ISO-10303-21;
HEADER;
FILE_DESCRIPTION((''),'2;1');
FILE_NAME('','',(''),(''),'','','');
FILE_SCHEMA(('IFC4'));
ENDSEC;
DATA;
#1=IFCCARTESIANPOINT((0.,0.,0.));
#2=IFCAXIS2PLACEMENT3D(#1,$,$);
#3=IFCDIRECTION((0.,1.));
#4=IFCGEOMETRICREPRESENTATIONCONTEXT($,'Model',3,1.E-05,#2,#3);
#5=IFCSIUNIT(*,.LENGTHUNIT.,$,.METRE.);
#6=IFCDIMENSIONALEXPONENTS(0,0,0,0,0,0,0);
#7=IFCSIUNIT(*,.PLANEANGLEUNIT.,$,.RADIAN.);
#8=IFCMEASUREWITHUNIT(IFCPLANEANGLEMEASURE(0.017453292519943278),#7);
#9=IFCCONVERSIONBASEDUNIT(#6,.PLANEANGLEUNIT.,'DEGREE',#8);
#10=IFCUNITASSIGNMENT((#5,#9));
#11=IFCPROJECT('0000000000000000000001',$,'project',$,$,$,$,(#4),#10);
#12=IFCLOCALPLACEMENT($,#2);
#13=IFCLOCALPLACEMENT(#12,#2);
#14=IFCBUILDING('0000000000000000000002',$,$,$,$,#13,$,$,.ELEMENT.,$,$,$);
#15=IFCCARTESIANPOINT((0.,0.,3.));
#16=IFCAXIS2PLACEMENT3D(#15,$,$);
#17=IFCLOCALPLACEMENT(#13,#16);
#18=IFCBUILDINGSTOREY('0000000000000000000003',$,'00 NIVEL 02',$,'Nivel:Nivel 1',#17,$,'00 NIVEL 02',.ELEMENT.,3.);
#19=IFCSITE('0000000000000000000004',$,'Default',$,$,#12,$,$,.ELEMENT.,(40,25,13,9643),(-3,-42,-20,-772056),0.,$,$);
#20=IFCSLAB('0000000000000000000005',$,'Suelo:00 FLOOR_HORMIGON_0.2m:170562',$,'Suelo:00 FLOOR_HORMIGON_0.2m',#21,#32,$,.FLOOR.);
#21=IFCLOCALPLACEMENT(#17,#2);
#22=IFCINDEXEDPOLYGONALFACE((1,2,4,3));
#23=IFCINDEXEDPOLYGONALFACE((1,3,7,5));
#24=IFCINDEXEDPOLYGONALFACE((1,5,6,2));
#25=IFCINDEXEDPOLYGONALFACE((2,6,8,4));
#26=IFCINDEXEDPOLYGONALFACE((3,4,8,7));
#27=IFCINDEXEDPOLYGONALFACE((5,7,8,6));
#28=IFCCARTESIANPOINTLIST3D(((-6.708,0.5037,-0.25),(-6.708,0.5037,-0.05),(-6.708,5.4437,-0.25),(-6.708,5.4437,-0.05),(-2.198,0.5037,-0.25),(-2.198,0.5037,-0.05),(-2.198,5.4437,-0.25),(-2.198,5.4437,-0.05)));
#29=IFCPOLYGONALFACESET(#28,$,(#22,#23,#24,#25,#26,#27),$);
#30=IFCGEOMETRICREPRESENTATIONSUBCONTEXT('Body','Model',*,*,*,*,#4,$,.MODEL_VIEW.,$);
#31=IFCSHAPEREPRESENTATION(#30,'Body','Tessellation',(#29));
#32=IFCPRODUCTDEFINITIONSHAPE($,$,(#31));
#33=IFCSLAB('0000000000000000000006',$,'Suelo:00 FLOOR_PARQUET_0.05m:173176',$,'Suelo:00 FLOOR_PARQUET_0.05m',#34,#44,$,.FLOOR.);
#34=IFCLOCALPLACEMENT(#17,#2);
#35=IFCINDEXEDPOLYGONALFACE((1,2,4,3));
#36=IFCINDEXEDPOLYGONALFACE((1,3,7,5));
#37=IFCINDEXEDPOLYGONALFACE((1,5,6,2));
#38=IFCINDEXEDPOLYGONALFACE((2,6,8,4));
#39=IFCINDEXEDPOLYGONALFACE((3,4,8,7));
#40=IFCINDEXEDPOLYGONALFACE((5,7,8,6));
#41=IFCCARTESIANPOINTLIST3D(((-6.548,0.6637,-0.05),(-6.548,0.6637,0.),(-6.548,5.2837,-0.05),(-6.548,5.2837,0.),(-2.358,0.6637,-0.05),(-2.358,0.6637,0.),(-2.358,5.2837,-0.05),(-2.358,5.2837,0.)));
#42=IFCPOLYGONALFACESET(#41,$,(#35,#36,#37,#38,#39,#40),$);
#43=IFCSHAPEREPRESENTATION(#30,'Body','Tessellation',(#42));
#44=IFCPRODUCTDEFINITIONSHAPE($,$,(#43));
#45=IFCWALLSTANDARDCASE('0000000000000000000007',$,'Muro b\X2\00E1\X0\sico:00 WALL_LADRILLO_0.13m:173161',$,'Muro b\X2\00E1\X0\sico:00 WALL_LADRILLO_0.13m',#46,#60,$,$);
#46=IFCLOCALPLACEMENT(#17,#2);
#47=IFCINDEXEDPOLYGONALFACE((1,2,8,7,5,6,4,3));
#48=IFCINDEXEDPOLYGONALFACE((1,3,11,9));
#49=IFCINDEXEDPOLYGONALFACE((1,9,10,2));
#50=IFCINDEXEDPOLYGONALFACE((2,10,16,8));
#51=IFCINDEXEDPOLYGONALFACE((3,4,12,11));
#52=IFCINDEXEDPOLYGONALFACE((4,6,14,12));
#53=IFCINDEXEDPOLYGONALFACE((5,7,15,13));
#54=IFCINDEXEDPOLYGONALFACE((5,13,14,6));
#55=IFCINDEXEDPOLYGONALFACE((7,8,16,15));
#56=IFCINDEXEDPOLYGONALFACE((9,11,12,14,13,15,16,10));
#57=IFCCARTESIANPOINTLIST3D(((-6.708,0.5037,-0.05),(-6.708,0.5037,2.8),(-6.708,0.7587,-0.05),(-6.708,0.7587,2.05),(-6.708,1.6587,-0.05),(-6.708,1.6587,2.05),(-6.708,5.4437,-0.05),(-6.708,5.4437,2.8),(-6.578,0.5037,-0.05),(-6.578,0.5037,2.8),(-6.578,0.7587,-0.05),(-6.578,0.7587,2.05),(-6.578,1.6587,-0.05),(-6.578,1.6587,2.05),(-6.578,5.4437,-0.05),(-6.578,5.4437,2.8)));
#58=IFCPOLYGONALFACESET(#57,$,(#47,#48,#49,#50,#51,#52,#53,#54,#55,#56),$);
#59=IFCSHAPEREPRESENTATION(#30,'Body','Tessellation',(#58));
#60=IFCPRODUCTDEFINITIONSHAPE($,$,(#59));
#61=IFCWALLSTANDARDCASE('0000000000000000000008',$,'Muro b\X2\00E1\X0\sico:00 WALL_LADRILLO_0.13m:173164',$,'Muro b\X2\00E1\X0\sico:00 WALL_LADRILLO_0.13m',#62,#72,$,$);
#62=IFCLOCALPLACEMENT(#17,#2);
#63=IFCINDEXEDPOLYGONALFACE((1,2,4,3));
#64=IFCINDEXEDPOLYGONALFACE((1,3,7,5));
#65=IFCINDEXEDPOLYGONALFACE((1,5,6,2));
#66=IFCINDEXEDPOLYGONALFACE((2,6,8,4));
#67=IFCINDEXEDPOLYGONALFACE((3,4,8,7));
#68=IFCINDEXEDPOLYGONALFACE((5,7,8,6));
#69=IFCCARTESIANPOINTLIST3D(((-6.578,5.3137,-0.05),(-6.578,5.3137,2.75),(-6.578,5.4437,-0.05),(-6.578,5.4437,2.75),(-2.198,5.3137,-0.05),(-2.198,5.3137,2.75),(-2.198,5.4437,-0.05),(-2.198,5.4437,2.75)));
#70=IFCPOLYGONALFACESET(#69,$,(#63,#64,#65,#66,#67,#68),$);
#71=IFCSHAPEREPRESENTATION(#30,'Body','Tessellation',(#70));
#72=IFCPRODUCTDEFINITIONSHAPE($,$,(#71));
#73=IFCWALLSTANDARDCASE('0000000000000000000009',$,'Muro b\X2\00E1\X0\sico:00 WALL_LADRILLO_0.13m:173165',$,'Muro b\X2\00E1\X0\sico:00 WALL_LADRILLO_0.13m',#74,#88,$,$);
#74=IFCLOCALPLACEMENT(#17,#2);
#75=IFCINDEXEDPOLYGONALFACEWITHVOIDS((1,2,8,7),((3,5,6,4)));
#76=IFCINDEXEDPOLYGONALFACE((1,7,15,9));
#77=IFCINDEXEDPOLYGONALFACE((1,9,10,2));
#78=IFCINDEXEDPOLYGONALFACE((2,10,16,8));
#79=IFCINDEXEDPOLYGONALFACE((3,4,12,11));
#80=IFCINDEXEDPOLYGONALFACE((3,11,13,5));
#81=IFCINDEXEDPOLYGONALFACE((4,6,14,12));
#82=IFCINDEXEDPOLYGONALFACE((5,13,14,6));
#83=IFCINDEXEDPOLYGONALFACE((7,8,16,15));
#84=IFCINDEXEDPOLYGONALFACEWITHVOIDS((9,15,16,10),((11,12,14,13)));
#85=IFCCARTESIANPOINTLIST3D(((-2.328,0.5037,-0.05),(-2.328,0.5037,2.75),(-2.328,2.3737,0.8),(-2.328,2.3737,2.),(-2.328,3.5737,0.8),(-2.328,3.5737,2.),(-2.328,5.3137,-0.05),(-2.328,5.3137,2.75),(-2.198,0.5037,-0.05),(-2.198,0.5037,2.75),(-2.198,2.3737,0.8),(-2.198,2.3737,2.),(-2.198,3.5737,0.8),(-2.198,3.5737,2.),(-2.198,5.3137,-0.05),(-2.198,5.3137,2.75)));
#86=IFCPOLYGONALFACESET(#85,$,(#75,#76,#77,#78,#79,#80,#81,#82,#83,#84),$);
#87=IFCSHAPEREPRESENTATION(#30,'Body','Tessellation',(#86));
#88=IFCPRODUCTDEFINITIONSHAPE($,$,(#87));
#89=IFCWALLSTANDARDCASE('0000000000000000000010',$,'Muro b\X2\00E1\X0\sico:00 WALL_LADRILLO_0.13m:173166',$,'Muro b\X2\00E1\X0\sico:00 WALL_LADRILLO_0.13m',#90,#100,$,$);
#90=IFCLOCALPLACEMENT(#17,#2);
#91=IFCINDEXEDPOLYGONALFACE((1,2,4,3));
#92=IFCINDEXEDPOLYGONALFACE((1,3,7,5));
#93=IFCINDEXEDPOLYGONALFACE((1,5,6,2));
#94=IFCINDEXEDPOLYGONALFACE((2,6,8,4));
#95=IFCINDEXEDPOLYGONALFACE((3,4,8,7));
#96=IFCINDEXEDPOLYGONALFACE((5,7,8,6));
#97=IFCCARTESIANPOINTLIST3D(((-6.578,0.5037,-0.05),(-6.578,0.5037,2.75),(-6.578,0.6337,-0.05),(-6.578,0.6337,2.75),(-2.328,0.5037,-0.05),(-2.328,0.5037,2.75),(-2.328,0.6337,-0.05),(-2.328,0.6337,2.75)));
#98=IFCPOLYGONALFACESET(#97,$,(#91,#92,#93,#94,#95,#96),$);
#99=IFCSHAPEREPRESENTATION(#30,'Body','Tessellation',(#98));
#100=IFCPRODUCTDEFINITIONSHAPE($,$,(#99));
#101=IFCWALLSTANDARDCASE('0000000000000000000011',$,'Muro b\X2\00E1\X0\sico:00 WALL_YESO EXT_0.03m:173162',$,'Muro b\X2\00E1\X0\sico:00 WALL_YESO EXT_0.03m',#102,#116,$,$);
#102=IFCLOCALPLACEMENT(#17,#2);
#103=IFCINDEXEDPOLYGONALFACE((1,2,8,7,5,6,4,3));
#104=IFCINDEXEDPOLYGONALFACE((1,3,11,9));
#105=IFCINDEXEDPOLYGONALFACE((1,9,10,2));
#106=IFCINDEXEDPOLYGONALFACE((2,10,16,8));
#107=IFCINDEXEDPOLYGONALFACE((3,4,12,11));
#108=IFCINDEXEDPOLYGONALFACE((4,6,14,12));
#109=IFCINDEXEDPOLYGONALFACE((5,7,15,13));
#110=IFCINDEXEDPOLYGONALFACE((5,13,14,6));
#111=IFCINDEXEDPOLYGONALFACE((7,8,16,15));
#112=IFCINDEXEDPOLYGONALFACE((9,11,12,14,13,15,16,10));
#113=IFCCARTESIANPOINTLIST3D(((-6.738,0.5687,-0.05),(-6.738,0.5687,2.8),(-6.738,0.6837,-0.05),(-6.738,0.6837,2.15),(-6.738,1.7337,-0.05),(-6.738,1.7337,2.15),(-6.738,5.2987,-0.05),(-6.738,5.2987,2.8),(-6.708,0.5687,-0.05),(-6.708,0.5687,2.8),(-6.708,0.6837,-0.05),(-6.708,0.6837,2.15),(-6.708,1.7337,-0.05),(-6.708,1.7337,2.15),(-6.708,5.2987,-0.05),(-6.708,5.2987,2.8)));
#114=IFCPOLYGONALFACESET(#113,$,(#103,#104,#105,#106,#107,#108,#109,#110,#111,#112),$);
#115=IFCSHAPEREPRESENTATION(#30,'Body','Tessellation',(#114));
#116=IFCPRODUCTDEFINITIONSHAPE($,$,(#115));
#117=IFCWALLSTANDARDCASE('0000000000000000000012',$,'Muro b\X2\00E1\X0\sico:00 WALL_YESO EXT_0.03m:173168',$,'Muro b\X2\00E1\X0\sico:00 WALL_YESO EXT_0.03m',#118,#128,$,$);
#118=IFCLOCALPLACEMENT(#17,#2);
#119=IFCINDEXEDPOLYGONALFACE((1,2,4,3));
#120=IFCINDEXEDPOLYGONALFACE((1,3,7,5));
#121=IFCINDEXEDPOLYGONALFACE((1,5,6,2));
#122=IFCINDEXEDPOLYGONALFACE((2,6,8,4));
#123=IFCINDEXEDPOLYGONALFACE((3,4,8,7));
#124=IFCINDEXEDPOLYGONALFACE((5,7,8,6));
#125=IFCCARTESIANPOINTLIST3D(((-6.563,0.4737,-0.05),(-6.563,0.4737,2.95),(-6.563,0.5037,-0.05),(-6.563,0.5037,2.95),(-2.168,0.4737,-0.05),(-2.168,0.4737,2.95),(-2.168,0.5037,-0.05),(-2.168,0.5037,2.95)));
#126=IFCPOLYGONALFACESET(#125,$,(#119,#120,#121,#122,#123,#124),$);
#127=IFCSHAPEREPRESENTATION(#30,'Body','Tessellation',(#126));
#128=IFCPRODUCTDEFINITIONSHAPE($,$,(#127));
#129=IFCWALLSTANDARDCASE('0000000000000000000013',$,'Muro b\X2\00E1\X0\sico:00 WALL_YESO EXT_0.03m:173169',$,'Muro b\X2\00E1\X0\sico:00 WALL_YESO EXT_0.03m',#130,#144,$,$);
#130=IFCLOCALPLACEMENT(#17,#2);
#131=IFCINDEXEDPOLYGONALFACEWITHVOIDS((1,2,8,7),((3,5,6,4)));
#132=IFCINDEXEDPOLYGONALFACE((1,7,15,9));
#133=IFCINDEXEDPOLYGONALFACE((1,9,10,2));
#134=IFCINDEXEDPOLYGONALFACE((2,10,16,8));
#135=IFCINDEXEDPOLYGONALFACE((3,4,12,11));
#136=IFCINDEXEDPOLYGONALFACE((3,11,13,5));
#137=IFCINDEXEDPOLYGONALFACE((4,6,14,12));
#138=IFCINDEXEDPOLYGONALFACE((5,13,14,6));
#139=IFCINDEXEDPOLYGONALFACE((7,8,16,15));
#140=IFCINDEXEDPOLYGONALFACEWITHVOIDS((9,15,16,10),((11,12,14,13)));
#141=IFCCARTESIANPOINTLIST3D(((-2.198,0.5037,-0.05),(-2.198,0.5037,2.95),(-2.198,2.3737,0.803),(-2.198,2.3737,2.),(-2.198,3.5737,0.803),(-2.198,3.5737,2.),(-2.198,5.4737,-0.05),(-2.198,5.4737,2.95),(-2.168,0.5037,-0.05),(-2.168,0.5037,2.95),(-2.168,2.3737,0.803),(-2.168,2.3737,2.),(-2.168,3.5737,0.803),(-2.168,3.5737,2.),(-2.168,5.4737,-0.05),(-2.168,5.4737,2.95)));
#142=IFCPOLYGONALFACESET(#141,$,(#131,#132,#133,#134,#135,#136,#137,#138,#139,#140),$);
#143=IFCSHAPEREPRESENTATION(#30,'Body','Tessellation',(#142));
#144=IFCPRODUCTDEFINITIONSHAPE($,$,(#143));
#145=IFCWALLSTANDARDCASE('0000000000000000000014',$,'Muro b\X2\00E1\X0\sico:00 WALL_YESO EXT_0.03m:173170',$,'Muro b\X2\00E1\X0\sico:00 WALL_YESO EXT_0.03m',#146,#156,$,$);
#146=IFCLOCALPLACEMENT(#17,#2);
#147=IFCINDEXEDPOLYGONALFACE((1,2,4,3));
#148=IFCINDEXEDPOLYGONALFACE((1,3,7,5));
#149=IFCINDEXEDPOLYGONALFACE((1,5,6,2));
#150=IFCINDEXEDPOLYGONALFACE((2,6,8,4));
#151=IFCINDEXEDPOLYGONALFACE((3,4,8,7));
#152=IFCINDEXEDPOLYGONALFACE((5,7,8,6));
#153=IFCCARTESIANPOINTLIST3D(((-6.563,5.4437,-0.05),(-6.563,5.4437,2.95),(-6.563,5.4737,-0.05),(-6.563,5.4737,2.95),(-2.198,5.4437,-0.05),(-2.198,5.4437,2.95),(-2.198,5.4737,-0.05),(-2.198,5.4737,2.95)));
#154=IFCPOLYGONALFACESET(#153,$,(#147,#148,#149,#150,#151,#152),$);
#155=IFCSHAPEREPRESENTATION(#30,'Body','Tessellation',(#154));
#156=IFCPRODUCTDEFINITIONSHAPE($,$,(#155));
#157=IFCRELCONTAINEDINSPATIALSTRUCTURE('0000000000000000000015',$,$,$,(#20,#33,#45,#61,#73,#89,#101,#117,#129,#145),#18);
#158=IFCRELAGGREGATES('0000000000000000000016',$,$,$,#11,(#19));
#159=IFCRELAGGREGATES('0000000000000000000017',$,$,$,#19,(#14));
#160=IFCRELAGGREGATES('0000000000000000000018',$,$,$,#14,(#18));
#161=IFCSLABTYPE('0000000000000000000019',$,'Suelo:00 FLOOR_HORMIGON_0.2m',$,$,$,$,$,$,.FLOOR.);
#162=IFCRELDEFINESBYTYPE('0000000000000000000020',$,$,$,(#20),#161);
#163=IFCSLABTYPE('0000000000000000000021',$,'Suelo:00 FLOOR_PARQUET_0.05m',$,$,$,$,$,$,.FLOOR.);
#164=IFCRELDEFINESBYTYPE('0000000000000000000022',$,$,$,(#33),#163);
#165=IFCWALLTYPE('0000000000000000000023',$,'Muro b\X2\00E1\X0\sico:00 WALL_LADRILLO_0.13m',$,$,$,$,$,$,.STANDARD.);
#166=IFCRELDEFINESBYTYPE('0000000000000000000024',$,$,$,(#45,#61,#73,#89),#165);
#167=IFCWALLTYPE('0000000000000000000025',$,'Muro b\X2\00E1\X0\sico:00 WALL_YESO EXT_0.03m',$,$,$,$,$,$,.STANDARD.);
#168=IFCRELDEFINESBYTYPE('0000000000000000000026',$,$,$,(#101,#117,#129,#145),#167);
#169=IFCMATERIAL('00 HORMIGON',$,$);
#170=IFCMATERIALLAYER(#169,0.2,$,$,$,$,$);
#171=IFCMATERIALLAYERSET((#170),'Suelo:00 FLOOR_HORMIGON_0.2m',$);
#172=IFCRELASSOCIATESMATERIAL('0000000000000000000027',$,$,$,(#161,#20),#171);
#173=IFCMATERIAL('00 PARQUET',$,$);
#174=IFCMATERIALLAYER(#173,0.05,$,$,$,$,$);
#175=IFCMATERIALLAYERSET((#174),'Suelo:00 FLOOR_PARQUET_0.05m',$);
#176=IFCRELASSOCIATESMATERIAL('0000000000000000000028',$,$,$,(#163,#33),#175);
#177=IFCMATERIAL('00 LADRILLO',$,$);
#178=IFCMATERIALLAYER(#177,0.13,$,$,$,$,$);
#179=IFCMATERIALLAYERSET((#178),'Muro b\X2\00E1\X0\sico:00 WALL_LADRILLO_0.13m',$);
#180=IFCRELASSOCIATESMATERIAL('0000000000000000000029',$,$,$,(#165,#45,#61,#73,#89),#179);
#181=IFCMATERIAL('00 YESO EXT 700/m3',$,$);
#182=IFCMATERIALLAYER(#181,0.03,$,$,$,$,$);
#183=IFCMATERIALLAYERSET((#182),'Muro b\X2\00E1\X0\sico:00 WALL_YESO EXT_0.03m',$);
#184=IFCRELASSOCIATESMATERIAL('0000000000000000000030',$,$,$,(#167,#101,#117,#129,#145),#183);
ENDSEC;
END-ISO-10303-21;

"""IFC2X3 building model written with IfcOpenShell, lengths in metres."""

from ifc_helpers import new_model, entity, si_unit, converted_unit, direction, frame, frame_2d, origin, place, context, subcontext, project, spatial, rectangle, extrude, material, layer, layer_set, layer_usage, type_object, element, save


model = new_model("IFC2X3")

# Units and contexts
model_context = context("Model", 3, precision=1e-05, world=origin(), true_north=direction((0.0, 1.0)))
body_context = subcontext(model_context, "Body", "Model", "MODEL_VIEW")
ifc_project = project(units=[si_unit("LENGTHUNIT", "METRE"), converted_unit("PLANEANGLEUNIT", "DEGREE", entity("IfcPlaneAngleMeasure", 0.017453292519943278), si_unit("PLANEANGLEUNIT", "RADIAN"), dimensions=[0, 0, 0, 0, 0, 0, 0])], contexts=[model_context])

# Site, building, storey
site_placement = place(None, origin())
site = spatial("IfcSite", under=ifc_project, at=site_placement, Name="Default", CompositionType="ELEMENT", RefLatitude=(40, 25, 13, 9643), RefLongitude=(-3, -42, -20, -772056), RefElevation=0.0)
building_placement = place(site_placement, origin())
building = spatial("IfcBuilding", under=site, at=building_placement, CompositionType="ELEMENT")
storey_placement = place(building_placement, frame((0.0, 0.0, 3.0)))
storey = spatial("IfcBuildingStorey", under=building, at=storey_placement, Name="00 NIVEL 02", ObjectType="Nivel:Nivel 1", LongName="00 NIVEL 02", CompositionType="ELEMENT", Elevation=3.0)

# Slabs
ifc_material_1 = material(Name="00 HORMIGON")
ifc_layer_1 = layer(ifc_material_1, 0.2)
ifc_layer_set_1 = layer_set([ifc_layer_1], Name="Suelo:00 FLOOR_HORMIGON_0.2m")
ifc_layer_usage_1 = layer_usage(ifc_layer_set_1, "AXIS3", "POSITIVE", 0.0)
slab_type_1 = type_object("IfcSlabType", Name="Suelo:00 FLOOR_HORMIGON_0.2m", PredefinedType="FLOOR", material=ifc_layer_set_1)
slab_1_placement = place(storey_placement, origin())
element("IfcSlab", 1, at=slab_1_placement, inside=storey, type_object=slab_type_1, material=ifc_layer_usage_1, Name="Suelo:00 FLOOR_HORMIGON_0.2m:170562", ObjectType="Suelo:00 FLOOR_HORMIGON_0.2m", PredefinedType="FLOOR", context=body_context, shape_type="SweptSolid", body=[
    extrude(rectangle(XDim=4.94, YDim=4.51, at=frame_2d((0.0, 0.0), x_axis=(1.0, 0.0))), frame((-4.453, 2.9737, -0.05), z_axis=(0.0, 0.0, -1.0), x_axis=(0.0, 1.0, 0.0)), (0.0, 0.0, 1.0), 0.2),
])
ifc_material_2 = material(Name="00 PARQUET")
ifc_layer_2 = layer(ifc_material_2, 0.05)
ifc_layer_set_2 = layer_set([ifc_layer_2], Name="Suelo:00 FLOOR_PARQUET_0.05m")
ifc_layer_usage_2 = layer_usage(ifc_layer_set_2, "AXIS3", "POSITIVE", 0.0)
slab_type_2 = type_object("IfcSlabType", Name="Suelo:00 FLOOR_PARQUET_0.05m", PredefinedType="FLOOR", material=ifc_layer_set_2)
slab_2_placement = place(storey_placement, origin())
element("IfcSlab", 2, at=slab_2_placement, inside=storey, type_object=slab_type_2, material=ifc_layer_usage_2, Name="Suelo:00 FLOOR_PARQUET_0.05m:173176", ObjectType="Suelo:00 FLOOR_PARQUET_0.05m", PredefinedType="FLOOR", context=body_context, shape_type="SweptSolid", body=[
    extrude(rectangle(XDim=4.62, YDim=4.19, at=frame_2d((0.0, 0.0), x_axis=(1.0, 0.0))), frame((-4.453, 2.9737, 0.0), z_axis=(0.0, 0.0, -1.0), x_axis=(0.0, 1.0, 0.0)), (0.0, 0.0, 1.0), 0.05),
])

# Wall, opening
ifc_material_3 = material(Name="00 LADRILLO")
ifc_layer_3 = layer(ifc_material_3, 0.13)
ifc_layer_set_3 = layer_set([ifc_layer_3], Name="Muro básico:00 WALL_LADRILLO_0.13m")
ifc_layer_usage_3 = layer_usage(ifc_layer_set_3, "AXIS2", "NEGATIVE", 0.065)
wall_type_1 = type_object("IfcWallType", Name="Muro básico:00 WALL_LADRILLO_0.13m", PredefinedType="STANDARD", material=ifc_layer_set_3)
wall_1_placement = place(storey_placement, frame((-6.643, 5.4437, -0.05), z_axis=(0.0, 0.0, 1.0), x_axis=(0.0, -1.0, 0.0)))
wall_1 = element("IfcWallStandardCase", 3, at=wall_1_placement, inside=storey, type_object=wall_type_1, material=ifc_layer_usage_3, Name="Muro básico:00 WALL_LADRILLO_0.13m:173161", ObjectType="Muro básico:00 WALL_LADRILLO_0.13m", context=body_context, shape_type="SweptSolid", body=[
    extrude(rectangle(XDim=4.94, YDim=0.13, at=frame_2d((2.47, 0.0), x_axis=(-1.0, 0.0))), origin(), (0.0, 0.0, 1.0), 2.85),
])
opening_1_placement = place(wall_1_placement, frame((3.785, -0.065, 0.0)))
element("IfcOpeningElement", 4, at=opening_1_placement, cuts=wall_1, ObjectType="Opening", context=body_context, shape_type="SweptSolid", body=[
    extrude(rectangle(XDim=2.1, YDim=0.9, at=frame_2d((1.05, 0.45), x_axis=(1.0, 0.0))), frame((0.0, 0.0, 0.0), z_axis=(0.0, 1.0, 0.0), x_axis=(0.0, 0.0, 1.0)), (0.0, 0.0, 1.0), 0.13),
])

# Wall
ifc_layer_usage_4 = layer_usage(ifc_layer_set_3, "AXIS2", "NEGATIVE", 0.065)
wall_2_placement = place(storey_placement, frame((-6.578, 5.3787, -0.05)))
element("IfcWallStandardCase", 5, at=wall_2_placement, inside=storey, type_object=wall_type_1, material=ifc_layer_usage_4, Name="Muro básico:00 WALL_LADRILLO_0.13m:173164", ObjectType="Muro básico:00 WALL_LADRILLO_0.13m", context=body_context, shape_type="SweptSolid", body=[
    extrude(rectangle(XDim=4.38, YDim=0.13, at=frame_2d((2.19, 0.0), x_axis=(-1.0, 0.0))), origin(), (0.0, 0.0, 1.0), 2.8),
])

# Wall, opening
ifc_layer_usage_5 = layer_usage(ifc_layer_set_3, "AXIS2", "NEGATIVE", 0.065)
wall_3_placement = place(storey_placement, frame((-2.263, 5.3137, -0.05), z_axis=(0.0, 0.0, 1.0), x_axis=(0.0, -1.0, 0.0)))
wall_3 = element("IfcWallStandardCase", 6, at=wall_3_placement, inside=storey, type_object=wall_type_1, material=ifc_layer_usage_5, Name="Muro básico:00 WALL_LADRILLO_0.13m:173165", ObjectType="Muro básico:00 WALL_LADRILLO_0.13m", context=body_context, shape_type="SweptSolid", body=[
    extrude(rectangle(XDim=4.81, YDim=0.13, at=frame_2d((2.405, 0.0), x_axis=(-1.0, 0.0))), origin(), (0.0, 0.0, 1.0), 2.8),
])
opening_2_placement = place(wall_3_placement, frame((2.94, 0.065, 0.85)))
element("IfcOpeningElement", 7, at=opening_2_placement, cuts=wall_3, ObjectType="Opening", context=body_context, shape_type="SweptSolid", body=[
    extrude(rectangle(XDim=1.2, YDim=1.2, at=frame_2d((0.6, 0.6), x_axis=(1.0, 0.0))), frame((0.0, 0.0, 0.0), z_axis=(0.0, -1.0, 0.0), x_axis=(0.0, 0.0, 1.0)), (0.0, 0.0, 1.0), 0.13),
])

# Wall
ifc_layer_usage_6 = layer_usage(ifc_layer_set_3, "AXIS2", "POSITIVE", -0.065)
wall_4_placement = place(storey_placement, frame((-6.578, 0.5687, -0.05)))
element("IfcWallStandardCase", 8, at=wall_4_placement, inside=storey, type_object=wall_type_1, material=ifc_layer_usage_6, Name="Muro básico:00 WALL_LADRILLO_0.13m:173166", ObjectType="Muro básico:00 WALL_LADRILLO_0.13m", context=body_context, shape_type="SweptSolid", body=[
    extrude(rectangle(XDim=4.25, YDim=0.13, at=frame_2d((2.125, 0.0), x_axis=(-1.0, 0.0))), origin(), (0.0, 0.0, 1.0), 2.8),
])

# Wall, opening
ifc_material_4 = material(Name="00 YESO EXT 700/m3")
ifc_layer_4 = layer(ifc_material_4, 0.03)
ifc_layer_set_4 = layer_set([ifc_layer_4], Name="Muro básico:00 WALL_YESO EXT_0.03m")
ifc_layer_usage_7 = layer_usage(ifc_layer_set_4, "AXIS2", "NEGATIVE", 0.015)
wall_type_2 = type_object("IfcWallType", Name="Muro básico:00 WALL_YESO EXT_0.03m", PredefinedType="STANDARD", material=ifc_layer_set_4)
wall_5_placement = place(storey_placement, frame((-6.723, 5.2987, -0.05), z_axis=(0.0, 0.0, 1.0), x_axis=(0.0, -1.0, 0.0)))
wall_5 = element("IfcWallStandardCase", 9, at=wall_5_placement, inside=storey, type_object=wall_type_2, material=ifc_layer_usage_7, Name="Muro básico:00 WALL_YESO EXT_0.03m:173162", ObjectType="Muro básico:00 WALL_YESO EXT_0.03m", context=body_context, shape_type="SweptSolid", body=[
    extrude(rectangle(XDim=4.73, YDim=0.03, at=frame_2d((2.365, 0.0), x_axis=(-1.0, 0.0))), origin(), (0.0, 0.0, 1.0), 2.85),
])
opening_3_placement = place(wall_5_placement, origin())
element("IfcOpeningElement", 10, at=opening_3_placement, cuts=wall_5, ObjectType="Opening", context=body_context, shape_type="SweptSolid", body=[
    extrude(rectangle(XDim=2.2, YDim=1.05, at=frame_2d((0.0, 0.0), x_axis=(0.0, 1.0))), frame((4.09, 0.015, 1.1), z_axis=(0.0, -1.0, 0.0), x_axis=(1.0, 0.0, 0.0)), (0.0, 0.0, 1.0), 0.03),
])

# Wall
ifc_layer_usage_8 = layer_usage(ifc_layer_set_4, "AXIS2", "NEGATIVE", 0.015)
wall_6_placement = place(storey_placement, frame((-6.563, 0.4887, -0.05)))
element("IfcWallStandardCase", 11, at=wall_6_placement, inside=storey, type_object=wall_type_2, material=ifc_layer_usage_8, Name="Muro básico:00 WALL_YESO EXT_0.03m:173168", ObjectType="Muro básico:00 WALL_YESO EXT_0.03m", context=body_context, shape_type="SweptSolid", body=[
    extrude(rectangle(XDim=4.395, YDim=0.03, at=frame_2d((2.1975, 0.0), x_axis=(-1.0, 0.0))), origin(), (0.0, 0.0, 1.0), 3.0),
])

# Wall, opening
ifc_layer_usage_9 = layer_usage(ifc_layer_set_4, "AXIS2", "NEGATIVE", 0.015)
wall_7_placement = place(storey_placement, frame((-2.183, 0.5037, -0.05), z_axis=(0.0, 0.0, 1.0), x_axis=(0.0, 1.0, 0.0)))
wall_7 = element("IfcWallStandardCase", 12, at=wall_7_placement, inside=storey, type_object=wall_type_2, material=ifc_layer_usage_9, Name="Muro básico:00 WALL_YESO EXT_0.03m:173169", ObjectType="Muro básico:00 WALL_YESO EXT_0.03m", context=body_context, shape_type="SweptSolid", body=[
    extrude(rectangle(XDim=4.97, YDim=0.03, at=frame_2d((2.485, 0.0), x_axis=(-1.0, 0.0))), origin(), (0.0, 0.0, 1.0), 3.0),
])
opening_4_placement = place(wall_7_placement, origin())
element("IfcOpeningElement", 13, at=opening_4_placement, cuts=wall_7, ObjectType="Opening", context=body_context, shape_type="SweptSolid", body=[
    extrude(rectangle(XDim=1.197, YDim=1.2, at=frame_2d((0.0, 0.0), x_axis=(0.0, 1.0))), frame((2.47, 0.015, 1.4515), z_axis=(0.0, -1.0, 0.0), x_axis=(-1.0, 0.0, 0.0)), (0.0, 0.0, 1.0), 0.03),
])

# Wall
ifc_layer_usage_10 = layer_usage(ifc_layer_set_4, "AXIS2", "NEGATIVE", 0.015)
wall_8_placement = place(storey_placement, frame((-2.198, 5.4587, -0.05), z_axis=(0.0, 0.0, 1.0), x_axis=(-1.0, 0.0, 0.0)))
element("IfcWallStandardCase", 14, at=wall_8_placement, inside=storey, type_object=wall_type_2, material=ifc_layer_usage_10, Name="Muro básico:00 WALL_YESO EXT_0.03m:173170", ObjectType="Muro básico:00 WALL_YESO EXT_0.03m", context=body_context, shape_type="SweptSolid", body=[
    extrude(rectangle(XDim=4.365, YDim=0.03, at=frame_2d((2.1825, 0.0), x_axis=(-1.0, 0.0))), origin(), (0.0, 0.0, 1.0), 3.0),
])

save(model, "model.ifc")
